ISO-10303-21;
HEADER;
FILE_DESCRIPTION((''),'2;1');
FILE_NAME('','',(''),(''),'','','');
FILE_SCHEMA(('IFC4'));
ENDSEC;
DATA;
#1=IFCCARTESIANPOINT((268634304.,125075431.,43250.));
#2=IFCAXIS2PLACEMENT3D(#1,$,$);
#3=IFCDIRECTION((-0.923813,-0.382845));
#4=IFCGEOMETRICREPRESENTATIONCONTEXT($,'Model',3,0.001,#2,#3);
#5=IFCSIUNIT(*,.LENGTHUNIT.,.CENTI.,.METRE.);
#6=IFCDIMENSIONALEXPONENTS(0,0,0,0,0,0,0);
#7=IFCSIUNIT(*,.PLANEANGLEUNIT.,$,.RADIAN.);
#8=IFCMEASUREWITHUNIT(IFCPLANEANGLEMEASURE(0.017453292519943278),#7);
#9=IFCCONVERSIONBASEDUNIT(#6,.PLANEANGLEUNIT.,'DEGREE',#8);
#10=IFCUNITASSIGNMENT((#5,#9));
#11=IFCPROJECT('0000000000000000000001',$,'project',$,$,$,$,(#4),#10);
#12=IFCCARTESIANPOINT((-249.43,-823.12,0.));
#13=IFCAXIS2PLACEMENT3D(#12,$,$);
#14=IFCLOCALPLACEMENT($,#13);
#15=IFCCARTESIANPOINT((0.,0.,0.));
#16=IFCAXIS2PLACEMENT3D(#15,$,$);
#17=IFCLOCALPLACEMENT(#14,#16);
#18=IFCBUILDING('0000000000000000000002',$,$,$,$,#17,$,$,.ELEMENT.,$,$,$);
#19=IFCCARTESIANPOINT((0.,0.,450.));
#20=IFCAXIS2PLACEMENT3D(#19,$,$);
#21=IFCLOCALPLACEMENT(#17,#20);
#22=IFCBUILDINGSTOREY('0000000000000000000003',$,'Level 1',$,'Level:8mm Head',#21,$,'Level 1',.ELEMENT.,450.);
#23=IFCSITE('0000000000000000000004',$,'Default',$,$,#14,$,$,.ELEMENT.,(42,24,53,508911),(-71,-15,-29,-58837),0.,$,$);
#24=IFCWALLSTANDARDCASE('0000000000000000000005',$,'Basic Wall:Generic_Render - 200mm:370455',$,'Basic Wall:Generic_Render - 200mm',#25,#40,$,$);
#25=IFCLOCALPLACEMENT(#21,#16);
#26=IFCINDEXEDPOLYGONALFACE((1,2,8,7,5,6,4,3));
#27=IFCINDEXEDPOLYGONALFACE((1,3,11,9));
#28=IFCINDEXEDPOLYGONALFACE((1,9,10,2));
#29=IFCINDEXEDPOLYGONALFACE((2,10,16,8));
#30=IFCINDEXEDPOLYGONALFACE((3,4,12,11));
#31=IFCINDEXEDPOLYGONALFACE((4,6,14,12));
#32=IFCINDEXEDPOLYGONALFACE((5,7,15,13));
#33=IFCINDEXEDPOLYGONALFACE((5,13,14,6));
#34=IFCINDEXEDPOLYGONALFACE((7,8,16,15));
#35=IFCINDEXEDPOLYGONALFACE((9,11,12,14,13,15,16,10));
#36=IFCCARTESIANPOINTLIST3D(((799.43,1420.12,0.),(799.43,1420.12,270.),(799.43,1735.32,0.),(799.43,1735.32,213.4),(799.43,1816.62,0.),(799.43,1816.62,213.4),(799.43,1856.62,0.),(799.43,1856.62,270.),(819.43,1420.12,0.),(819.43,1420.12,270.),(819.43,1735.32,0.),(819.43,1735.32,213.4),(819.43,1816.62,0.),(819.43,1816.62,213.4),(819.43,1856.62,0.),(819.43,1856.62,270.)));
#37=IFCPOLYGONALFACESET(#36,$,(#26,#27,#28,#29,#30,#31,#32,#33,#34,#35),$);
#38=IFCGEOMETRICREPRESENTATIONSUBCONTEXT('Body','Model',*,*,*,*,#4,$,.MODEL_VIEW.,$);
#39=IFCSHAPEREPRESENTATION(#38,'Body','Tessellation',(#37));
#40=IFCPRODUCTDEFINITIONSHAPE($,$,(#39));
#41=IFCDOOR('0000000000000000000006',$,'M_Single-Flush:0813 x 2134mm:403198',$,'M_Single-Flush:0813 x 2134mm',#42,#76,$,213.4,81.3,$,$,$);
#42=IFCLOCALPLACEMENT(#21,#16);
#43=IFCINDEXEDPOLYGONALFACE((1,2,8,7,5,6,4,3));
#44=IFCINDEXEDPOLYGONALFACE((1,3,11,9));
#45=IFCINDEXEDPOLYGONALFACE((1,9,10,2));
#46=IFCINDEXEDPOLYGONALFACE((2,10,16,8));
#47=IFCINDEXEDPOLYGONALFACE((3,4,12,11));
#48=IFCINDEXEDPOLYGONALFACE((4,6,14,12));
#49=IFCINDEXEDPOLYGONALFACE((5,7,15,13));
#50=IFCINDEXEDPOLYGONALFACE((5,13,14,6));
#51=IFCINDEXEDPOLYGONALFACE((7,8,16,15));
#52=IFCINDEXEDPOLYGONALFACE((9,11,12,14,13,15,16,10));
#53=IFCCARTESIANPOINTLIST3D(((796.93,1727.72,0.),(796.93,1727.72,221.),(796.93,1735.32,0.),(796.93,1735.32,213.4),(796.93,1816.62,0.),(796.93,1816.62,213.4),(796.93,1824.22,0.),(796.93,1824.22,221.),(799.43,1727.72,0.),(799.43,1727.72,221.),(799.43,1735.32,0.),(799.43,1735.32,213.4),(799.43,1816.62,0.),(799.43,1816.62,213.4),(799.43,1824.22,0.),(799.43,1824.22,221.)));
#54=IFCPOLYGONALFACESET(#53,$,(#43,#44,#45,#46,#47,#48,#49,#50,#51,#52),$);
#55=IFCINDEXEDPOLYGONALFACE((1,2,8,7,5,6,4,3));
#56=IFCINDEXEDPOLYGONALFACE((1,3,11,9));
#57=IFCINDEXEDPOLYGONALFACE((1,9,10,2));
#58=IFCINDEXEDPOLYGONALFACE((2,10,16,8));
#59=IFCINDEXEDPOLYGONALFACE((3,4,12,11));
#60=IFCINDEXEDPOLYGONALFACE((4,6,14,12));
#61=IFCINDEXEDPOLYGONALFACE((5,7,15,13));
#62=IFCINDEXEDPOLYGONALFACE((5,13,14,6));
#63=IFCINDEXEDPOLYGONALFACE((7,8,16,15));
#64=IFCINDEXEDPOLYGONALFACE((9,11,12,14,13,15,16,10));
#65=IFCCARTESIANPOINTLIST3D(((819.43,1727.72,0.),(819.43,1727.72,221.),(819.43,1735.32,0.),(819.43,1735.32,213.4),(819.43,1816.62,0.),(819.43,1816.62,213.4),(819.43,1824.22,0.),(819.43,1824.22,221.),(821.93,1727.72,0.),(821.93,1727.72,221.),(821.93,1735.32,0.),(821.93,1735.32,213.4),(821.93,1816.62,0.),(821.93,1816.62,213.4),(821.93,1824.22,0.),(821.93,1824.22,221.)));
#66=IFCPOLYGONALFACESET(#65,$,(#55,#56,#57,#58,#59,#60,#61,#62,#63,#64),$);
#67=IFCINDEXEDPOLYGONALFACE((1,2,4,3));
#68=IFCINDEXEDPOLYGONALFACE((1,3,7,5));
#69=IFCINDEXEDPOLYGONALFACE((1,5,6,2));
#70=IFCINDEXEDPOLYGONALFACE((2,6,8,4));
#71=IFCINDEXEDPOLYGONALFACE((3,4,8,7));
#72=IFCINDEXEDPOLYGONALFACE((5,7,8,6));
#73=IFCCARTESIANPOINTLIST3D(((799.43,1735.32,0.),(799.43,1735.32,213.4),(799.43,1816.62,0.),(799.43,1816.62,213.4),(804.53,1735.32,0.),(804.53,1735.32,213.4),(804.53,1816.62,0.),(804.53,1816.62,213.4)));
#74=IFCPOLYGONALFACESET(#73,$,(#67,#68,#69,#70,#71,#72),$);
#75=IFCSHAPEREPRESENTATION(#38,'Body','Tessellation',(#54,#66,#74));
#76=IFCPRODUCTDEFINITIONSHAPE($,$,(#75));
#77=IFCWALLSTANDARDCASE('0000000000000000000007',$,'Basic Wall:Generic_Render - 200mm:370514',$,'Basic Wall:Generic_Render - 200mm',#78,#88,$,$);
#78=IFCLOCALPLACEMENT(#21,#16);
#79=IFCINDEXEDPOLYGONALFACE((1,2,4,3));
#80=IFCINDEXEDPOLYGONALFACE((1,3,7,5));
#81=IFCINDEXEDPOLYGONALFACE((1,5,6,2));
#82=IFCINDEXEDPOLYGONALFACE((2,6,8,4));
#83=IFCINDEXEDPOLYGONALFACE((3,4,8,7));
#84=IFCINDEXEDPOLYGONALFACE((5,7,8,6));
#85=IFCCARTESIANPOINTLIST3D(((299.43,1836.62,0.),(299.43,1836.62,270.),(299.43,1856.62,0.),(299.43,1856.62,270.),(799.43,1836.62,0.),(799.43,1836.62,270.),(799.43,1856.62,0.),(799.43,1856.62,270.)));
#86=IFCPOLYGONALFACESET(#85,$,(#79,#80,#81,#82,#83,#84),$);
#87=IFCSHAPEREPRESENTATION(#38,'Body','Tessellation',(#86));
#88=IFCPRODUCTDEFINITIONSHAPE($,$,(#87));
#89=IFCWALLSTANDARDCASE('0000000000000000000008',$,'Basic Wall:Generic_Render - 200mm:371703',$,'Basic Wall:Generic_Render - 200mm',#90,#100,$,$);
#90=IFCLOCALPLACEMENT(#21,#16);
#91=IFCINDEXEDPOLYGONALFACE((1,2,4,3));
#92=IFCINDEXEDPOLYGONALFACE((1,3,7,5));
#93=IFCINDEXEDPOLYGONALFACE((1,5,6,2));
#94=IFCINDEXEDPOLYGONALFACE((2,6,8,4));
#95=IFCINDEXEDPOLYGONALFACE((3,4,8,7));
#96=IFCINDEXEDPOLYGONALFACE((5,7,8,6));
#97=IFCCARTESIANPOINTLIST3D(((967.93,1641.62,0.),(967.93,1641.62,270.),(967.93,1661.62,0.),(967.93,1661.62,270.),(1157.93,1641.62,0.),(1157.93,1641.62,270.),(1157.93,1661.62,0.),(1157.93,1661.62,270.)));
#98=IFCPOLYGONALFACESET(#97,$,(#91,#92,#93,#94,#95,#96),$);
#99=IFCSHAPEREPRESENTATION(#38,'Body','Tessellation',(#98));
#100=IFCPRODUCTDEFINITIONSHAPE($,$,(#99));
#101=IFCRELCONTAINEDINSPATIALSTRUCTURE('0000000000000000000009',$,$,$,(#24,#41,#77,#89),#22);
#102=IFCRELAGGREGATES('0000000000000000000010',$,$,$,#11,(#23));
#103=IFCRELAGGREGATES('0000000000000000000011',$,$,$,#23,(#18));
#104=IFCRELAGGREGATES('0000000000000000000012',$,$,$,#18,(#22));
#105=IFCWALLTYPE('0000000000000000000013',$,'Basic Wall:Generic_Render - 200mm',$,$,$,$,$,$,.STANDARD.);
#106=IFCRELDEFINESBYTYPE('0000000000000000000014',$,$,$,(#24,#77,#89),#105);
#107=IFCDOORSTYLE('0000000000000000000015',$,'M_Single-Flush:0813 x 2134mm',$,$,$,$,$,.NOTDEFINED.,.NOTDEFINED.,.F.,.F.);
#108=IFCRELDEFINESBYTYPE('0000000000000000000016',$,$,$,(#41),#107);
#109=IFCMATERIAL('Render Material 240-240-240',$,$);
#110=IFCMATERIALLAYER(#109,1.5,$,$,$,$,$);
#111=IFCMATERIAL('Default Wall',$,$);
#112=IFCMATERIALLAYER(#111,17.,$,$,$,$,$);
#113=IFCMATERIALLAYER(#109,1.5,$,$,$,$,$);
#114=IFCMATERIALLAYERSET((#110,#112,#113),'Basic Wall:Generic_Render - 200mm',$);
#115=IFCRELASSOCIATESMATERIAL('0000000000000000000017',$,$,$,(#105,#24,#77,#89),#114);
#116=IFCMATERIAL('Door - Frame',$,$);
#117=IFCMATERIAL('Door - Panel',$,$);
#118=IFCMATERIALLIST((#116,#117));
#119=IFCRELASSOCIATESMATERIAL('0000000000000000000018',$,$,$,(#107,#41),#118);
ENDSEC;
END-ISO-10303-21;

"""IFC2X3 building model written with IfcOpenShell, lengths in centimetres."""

from ifc_helpers import new_model, entity, si_unit, converted_unit, direction, frame, frame_2d, origin, place, context, subcontext, project, spatial, polyline, rectangle, outline, extrude, source, transform, mapped, material, material_list, layer, layer_set, layer_usage, type_object, type_shapes, element, fill, save


model = new_model("IFC2X3")

# Units and contexts
model_context = context("Model", 3, precision=0.001, world=frame((268634304.0, 125075431.0, 43250.0)), true_north=direction((-0.923813, -0.382845)))
body_context = subcontext(model_context, "Body", "Model", "MODEL_VIEW")
ifc_project = project(units=[si_unit("LENGTHUNIT", "METRE", prefix="CENTI"), converted_unit("PLANEANGLEUNIT", "DEGREE", entity("IfcPlaneAngleMeasure", 0.017453292519943278), si_unit("PLANEANGLEUNIT", "RADIAN"), dimensions=[0, 0, 0, 0, 0, 0, 0])], contexts=[model_context])

# Site, building, storey
site_placement = place(None, frame((-249.43, -823.12, 0.0)))
site = spatial("IfcSite", under=ifc_project, at=site_placement, Name="Default", CompositionType="ELEMENT", RefLatitude=(42, 24, 53, 508911), RefLongitude=(-71, -15, -29, -58837), RefElevation=0.0)
building_placement = place(site_placement, origin())
building = spatial("IfcBuilding", under=site, at=building_placement, CompositionType="ELEMENT")
storey_placement = place(building_placement, frame((0.0, 0.0, 450.0)))
storey = spatial("IfcBuildingStorey", under=building, at=storey_placement, Name="Level 1", ObjectType="Level:8mm Head", LongName="Level 1", CompositionType="ELEMENT", Elevation=450.0)

# Shared definitions
ifc_material_1 = material(Name="Render Material 240-240-240")

# Wall, opening, door
ifc_layer_1 = layer(ifc_material_1, 1.5)
ifc_material_2 = material(Name="Default Wall")
ifc_layer_2 = layer(ifc_material_2, 17.0)
ifc_layer_3 = layer(ifc_material_1, 1.5)
ifc_layer_set_1 = layer_set([ifc_layer_1, ifc_layer_2, ifc_layer_3], Name="Basic Wall:Generic_Render - 200mm")
wall_type_1 = type_object("IfcWallType", Name="Basic Wall:Generic_Render - 200mm", PredefinedType="STANDARD", material=ifc_layer_set_1)
ifc_material_3 = material(Name="Door - Frame")
ifc_material_4 = material(Name="Door - Panel")
ifc_material_list_1 = material_list([ifc_material_3, ifc_material_4])
ifc_layer_usage_1 = layer_usage(ifc_layer_set_1, "AXIS2", "NEGATIVE", 10.0)
wall_1_placement = place(storey_placement, frame((809.43, 1856.62, 0.0), z_axis=(0.0, 0.0, 1.0), x_axis=(0.0, -1.0, 0.0)))
wall_1 = element("IfcWallStandardCase", 1, at=wall_1_placement, inside=storey, type_object=wall_type_1, material=ifc_layer_usage_1, Name="Basic Wall:Generic_Render - 200mm:370455", ObjectType="Basic Wall:Generic_Render - 200mm", context=body_context, shape_type="SweptSolid", body=[
    extrude(rectangle(XDim=436.5, YDim=20.0, at=frame_2d((218.25, 0.0), x_axis=(-1.0, 0.0))), origin(), (0.0, 0.0, 1.0), 270.0),
])
opening_1_placement = place(wall_1_placement, frame((121.3, 10.0, 0.0)))
opening_1 = element("IfcOpeningElement", 2, at=opening_1_placement, cuts=wall_1, ObjectType="Opening", context=body_context, shape_type="SweptSolid", body=[
    extrude(rectangle(XDim=81.3, YDim=213.4, at=frame_2d((106.7, 40.65), x_axis=(0.0, 1.0))), frame((0.0, 0.0, 0.0), z_axis=(0.0, -1.0, 0.0), x_axis=(0.0, 0.0, 1.0)), (0.0, 0.0, 1.0), 20.0),
])
door_style_1 = type_object("IfcDoorStyle", Name="M_Single-Flush:0813 x 2134mm", ConstructionType="NOTDEFINED", OperationType="NOTDEFINED", ParameterTakesPrecedence=False, Sizeable=False, material=ifc_material_list_1)
shared_shape_1 = source(origin(), body_context, "Body", "SweptSolid", [
    extrude(outline(polyline([(-48.25, -112.4), (48.25, -112.4), (48.25, 108.6), (40.65, 108.6), (40.65, -104.8), (-40.65, -104.8), (-40.65, 108.6), (-48.25, 108.6), (-48.25, -112.4)])), frame((40.65, 20.0, 108.6), z_axis=(0.0, 1.0, 0.0), x_axis=(1.0, 0.0, 0.0)), (0.0, 0.0, 1.0), 2.5),
    extrude(outline(polyline([(-112.4, -48.25), (108.6, -48.25), (108.6, -40.65), (-104.8, -40.65), (-104.8, 40.65), (108.6, 40.65), (108.6, 48.25), (-112.4, 48.25), (-112.4, -48.25)])), frame((40.65, -2.5, 108.6), z_axis=(0.0, 1.0, 0.0), x_axis=(0.0, 0.0, -1.0)), (0.0, 0.0, 1.0), 2.5),
    extrude(rectangle(XDim=5.1, YDim=81.3, at=frame_2d((0.0, 0.0), x_axis=(1.0, 0.0))), frame((40.65, 17.45, 0.0), z_axis=(0.0, 0.0, 1.0), x_axis=(0.0, 1.0, 0.0)), (0.0, 0.0, 1.0), 213.4),
])
type_shapes(door_style_1, [shared_shape_1])
door_1_placement = place(opening_1_placement, frame((0.0, 0.0, 0.0), z_axis=(0.0, 0.0, 1.0), x_axis=(-1.0, 0.0, 0.0)))
door_1 = element("IfcDoor", 3, at=door_1_placement, inside=storey, type_object=door_style_1, material=ifc_material_list_1, Name="M_Single-Flush:0813 x 2134mm:403198", ObjectType="M_Single-Flush:0813 x 2134mm", OverallHeight=213.4, OverallWidth=81.3, context=body_context, shape_type="MappedRepresentation", body=[
    mapped(shared_shape_1, transform((0.0, 0.0, 0.0), scale=1.0)),
])
fill(opening_1, door_1)

# Walls
ifc_layer_usage_2 = layer_usage(ifc_layer_set_1, "AXIS2", "NEGATIVE", 10.0)
wall_2_placement = place(storey_placement, frame((799.43, 1846.62, 0.0), z_axis=(0.0, 0.0, 1.0), x_axis=(-1.0, 0.0, 0.0)))
element("IfcWallStandardCase", 4, at=wall_2_placement, inside=storey, type_object=wall_type_1, material=ifc_layer_usage_2, Name="Basic Wall:Generic_Render - 200mm:370514", ObjectType="Basic Wall:Generic_Render - 200mm", context=body_context, shape_type="SweptSolid", body=[
    extrude(rectangle(XDim=500.0, YDim=20.0, at=frame_2d((250.0, 0.0), x_axis=(-1.0, 0.0))), origin(), (0.0, 0.0, 1.0), 270.0),
])
ifc_layer_usage_3 = layer_usage(ifc_layer_set_1, "AXIS2", "NEGATIVE", 10.0)
wall_3_placement = place(storey_placement, frame((1157.93, 1651.62, 0.0), z_axis=(0.0, 0.0, 1.0), x_axis=(-1.0, 0.0, 0.0)))
element("IfcWallStandardCase", 5, at=wall_3_placement, inside=storey, type_object=wall_type_1, material=ifc_layer_usage_3, Name="Basic Wall:Generic_Render - 200mm:371703", ObjectType="Basic Wall:Generic_Render - 200mm", context=body_context, shape_type="SweptSolid", body=[
    extrude(rectangle(XDim=190.0, YDim=20.0, at=frame_2d((95.0, 0.0), x_axis=(-1.0, 0.0))), origin(), (0.0, 0.0, 1.0), 270.0),
])

save(model, "model.ifc")
